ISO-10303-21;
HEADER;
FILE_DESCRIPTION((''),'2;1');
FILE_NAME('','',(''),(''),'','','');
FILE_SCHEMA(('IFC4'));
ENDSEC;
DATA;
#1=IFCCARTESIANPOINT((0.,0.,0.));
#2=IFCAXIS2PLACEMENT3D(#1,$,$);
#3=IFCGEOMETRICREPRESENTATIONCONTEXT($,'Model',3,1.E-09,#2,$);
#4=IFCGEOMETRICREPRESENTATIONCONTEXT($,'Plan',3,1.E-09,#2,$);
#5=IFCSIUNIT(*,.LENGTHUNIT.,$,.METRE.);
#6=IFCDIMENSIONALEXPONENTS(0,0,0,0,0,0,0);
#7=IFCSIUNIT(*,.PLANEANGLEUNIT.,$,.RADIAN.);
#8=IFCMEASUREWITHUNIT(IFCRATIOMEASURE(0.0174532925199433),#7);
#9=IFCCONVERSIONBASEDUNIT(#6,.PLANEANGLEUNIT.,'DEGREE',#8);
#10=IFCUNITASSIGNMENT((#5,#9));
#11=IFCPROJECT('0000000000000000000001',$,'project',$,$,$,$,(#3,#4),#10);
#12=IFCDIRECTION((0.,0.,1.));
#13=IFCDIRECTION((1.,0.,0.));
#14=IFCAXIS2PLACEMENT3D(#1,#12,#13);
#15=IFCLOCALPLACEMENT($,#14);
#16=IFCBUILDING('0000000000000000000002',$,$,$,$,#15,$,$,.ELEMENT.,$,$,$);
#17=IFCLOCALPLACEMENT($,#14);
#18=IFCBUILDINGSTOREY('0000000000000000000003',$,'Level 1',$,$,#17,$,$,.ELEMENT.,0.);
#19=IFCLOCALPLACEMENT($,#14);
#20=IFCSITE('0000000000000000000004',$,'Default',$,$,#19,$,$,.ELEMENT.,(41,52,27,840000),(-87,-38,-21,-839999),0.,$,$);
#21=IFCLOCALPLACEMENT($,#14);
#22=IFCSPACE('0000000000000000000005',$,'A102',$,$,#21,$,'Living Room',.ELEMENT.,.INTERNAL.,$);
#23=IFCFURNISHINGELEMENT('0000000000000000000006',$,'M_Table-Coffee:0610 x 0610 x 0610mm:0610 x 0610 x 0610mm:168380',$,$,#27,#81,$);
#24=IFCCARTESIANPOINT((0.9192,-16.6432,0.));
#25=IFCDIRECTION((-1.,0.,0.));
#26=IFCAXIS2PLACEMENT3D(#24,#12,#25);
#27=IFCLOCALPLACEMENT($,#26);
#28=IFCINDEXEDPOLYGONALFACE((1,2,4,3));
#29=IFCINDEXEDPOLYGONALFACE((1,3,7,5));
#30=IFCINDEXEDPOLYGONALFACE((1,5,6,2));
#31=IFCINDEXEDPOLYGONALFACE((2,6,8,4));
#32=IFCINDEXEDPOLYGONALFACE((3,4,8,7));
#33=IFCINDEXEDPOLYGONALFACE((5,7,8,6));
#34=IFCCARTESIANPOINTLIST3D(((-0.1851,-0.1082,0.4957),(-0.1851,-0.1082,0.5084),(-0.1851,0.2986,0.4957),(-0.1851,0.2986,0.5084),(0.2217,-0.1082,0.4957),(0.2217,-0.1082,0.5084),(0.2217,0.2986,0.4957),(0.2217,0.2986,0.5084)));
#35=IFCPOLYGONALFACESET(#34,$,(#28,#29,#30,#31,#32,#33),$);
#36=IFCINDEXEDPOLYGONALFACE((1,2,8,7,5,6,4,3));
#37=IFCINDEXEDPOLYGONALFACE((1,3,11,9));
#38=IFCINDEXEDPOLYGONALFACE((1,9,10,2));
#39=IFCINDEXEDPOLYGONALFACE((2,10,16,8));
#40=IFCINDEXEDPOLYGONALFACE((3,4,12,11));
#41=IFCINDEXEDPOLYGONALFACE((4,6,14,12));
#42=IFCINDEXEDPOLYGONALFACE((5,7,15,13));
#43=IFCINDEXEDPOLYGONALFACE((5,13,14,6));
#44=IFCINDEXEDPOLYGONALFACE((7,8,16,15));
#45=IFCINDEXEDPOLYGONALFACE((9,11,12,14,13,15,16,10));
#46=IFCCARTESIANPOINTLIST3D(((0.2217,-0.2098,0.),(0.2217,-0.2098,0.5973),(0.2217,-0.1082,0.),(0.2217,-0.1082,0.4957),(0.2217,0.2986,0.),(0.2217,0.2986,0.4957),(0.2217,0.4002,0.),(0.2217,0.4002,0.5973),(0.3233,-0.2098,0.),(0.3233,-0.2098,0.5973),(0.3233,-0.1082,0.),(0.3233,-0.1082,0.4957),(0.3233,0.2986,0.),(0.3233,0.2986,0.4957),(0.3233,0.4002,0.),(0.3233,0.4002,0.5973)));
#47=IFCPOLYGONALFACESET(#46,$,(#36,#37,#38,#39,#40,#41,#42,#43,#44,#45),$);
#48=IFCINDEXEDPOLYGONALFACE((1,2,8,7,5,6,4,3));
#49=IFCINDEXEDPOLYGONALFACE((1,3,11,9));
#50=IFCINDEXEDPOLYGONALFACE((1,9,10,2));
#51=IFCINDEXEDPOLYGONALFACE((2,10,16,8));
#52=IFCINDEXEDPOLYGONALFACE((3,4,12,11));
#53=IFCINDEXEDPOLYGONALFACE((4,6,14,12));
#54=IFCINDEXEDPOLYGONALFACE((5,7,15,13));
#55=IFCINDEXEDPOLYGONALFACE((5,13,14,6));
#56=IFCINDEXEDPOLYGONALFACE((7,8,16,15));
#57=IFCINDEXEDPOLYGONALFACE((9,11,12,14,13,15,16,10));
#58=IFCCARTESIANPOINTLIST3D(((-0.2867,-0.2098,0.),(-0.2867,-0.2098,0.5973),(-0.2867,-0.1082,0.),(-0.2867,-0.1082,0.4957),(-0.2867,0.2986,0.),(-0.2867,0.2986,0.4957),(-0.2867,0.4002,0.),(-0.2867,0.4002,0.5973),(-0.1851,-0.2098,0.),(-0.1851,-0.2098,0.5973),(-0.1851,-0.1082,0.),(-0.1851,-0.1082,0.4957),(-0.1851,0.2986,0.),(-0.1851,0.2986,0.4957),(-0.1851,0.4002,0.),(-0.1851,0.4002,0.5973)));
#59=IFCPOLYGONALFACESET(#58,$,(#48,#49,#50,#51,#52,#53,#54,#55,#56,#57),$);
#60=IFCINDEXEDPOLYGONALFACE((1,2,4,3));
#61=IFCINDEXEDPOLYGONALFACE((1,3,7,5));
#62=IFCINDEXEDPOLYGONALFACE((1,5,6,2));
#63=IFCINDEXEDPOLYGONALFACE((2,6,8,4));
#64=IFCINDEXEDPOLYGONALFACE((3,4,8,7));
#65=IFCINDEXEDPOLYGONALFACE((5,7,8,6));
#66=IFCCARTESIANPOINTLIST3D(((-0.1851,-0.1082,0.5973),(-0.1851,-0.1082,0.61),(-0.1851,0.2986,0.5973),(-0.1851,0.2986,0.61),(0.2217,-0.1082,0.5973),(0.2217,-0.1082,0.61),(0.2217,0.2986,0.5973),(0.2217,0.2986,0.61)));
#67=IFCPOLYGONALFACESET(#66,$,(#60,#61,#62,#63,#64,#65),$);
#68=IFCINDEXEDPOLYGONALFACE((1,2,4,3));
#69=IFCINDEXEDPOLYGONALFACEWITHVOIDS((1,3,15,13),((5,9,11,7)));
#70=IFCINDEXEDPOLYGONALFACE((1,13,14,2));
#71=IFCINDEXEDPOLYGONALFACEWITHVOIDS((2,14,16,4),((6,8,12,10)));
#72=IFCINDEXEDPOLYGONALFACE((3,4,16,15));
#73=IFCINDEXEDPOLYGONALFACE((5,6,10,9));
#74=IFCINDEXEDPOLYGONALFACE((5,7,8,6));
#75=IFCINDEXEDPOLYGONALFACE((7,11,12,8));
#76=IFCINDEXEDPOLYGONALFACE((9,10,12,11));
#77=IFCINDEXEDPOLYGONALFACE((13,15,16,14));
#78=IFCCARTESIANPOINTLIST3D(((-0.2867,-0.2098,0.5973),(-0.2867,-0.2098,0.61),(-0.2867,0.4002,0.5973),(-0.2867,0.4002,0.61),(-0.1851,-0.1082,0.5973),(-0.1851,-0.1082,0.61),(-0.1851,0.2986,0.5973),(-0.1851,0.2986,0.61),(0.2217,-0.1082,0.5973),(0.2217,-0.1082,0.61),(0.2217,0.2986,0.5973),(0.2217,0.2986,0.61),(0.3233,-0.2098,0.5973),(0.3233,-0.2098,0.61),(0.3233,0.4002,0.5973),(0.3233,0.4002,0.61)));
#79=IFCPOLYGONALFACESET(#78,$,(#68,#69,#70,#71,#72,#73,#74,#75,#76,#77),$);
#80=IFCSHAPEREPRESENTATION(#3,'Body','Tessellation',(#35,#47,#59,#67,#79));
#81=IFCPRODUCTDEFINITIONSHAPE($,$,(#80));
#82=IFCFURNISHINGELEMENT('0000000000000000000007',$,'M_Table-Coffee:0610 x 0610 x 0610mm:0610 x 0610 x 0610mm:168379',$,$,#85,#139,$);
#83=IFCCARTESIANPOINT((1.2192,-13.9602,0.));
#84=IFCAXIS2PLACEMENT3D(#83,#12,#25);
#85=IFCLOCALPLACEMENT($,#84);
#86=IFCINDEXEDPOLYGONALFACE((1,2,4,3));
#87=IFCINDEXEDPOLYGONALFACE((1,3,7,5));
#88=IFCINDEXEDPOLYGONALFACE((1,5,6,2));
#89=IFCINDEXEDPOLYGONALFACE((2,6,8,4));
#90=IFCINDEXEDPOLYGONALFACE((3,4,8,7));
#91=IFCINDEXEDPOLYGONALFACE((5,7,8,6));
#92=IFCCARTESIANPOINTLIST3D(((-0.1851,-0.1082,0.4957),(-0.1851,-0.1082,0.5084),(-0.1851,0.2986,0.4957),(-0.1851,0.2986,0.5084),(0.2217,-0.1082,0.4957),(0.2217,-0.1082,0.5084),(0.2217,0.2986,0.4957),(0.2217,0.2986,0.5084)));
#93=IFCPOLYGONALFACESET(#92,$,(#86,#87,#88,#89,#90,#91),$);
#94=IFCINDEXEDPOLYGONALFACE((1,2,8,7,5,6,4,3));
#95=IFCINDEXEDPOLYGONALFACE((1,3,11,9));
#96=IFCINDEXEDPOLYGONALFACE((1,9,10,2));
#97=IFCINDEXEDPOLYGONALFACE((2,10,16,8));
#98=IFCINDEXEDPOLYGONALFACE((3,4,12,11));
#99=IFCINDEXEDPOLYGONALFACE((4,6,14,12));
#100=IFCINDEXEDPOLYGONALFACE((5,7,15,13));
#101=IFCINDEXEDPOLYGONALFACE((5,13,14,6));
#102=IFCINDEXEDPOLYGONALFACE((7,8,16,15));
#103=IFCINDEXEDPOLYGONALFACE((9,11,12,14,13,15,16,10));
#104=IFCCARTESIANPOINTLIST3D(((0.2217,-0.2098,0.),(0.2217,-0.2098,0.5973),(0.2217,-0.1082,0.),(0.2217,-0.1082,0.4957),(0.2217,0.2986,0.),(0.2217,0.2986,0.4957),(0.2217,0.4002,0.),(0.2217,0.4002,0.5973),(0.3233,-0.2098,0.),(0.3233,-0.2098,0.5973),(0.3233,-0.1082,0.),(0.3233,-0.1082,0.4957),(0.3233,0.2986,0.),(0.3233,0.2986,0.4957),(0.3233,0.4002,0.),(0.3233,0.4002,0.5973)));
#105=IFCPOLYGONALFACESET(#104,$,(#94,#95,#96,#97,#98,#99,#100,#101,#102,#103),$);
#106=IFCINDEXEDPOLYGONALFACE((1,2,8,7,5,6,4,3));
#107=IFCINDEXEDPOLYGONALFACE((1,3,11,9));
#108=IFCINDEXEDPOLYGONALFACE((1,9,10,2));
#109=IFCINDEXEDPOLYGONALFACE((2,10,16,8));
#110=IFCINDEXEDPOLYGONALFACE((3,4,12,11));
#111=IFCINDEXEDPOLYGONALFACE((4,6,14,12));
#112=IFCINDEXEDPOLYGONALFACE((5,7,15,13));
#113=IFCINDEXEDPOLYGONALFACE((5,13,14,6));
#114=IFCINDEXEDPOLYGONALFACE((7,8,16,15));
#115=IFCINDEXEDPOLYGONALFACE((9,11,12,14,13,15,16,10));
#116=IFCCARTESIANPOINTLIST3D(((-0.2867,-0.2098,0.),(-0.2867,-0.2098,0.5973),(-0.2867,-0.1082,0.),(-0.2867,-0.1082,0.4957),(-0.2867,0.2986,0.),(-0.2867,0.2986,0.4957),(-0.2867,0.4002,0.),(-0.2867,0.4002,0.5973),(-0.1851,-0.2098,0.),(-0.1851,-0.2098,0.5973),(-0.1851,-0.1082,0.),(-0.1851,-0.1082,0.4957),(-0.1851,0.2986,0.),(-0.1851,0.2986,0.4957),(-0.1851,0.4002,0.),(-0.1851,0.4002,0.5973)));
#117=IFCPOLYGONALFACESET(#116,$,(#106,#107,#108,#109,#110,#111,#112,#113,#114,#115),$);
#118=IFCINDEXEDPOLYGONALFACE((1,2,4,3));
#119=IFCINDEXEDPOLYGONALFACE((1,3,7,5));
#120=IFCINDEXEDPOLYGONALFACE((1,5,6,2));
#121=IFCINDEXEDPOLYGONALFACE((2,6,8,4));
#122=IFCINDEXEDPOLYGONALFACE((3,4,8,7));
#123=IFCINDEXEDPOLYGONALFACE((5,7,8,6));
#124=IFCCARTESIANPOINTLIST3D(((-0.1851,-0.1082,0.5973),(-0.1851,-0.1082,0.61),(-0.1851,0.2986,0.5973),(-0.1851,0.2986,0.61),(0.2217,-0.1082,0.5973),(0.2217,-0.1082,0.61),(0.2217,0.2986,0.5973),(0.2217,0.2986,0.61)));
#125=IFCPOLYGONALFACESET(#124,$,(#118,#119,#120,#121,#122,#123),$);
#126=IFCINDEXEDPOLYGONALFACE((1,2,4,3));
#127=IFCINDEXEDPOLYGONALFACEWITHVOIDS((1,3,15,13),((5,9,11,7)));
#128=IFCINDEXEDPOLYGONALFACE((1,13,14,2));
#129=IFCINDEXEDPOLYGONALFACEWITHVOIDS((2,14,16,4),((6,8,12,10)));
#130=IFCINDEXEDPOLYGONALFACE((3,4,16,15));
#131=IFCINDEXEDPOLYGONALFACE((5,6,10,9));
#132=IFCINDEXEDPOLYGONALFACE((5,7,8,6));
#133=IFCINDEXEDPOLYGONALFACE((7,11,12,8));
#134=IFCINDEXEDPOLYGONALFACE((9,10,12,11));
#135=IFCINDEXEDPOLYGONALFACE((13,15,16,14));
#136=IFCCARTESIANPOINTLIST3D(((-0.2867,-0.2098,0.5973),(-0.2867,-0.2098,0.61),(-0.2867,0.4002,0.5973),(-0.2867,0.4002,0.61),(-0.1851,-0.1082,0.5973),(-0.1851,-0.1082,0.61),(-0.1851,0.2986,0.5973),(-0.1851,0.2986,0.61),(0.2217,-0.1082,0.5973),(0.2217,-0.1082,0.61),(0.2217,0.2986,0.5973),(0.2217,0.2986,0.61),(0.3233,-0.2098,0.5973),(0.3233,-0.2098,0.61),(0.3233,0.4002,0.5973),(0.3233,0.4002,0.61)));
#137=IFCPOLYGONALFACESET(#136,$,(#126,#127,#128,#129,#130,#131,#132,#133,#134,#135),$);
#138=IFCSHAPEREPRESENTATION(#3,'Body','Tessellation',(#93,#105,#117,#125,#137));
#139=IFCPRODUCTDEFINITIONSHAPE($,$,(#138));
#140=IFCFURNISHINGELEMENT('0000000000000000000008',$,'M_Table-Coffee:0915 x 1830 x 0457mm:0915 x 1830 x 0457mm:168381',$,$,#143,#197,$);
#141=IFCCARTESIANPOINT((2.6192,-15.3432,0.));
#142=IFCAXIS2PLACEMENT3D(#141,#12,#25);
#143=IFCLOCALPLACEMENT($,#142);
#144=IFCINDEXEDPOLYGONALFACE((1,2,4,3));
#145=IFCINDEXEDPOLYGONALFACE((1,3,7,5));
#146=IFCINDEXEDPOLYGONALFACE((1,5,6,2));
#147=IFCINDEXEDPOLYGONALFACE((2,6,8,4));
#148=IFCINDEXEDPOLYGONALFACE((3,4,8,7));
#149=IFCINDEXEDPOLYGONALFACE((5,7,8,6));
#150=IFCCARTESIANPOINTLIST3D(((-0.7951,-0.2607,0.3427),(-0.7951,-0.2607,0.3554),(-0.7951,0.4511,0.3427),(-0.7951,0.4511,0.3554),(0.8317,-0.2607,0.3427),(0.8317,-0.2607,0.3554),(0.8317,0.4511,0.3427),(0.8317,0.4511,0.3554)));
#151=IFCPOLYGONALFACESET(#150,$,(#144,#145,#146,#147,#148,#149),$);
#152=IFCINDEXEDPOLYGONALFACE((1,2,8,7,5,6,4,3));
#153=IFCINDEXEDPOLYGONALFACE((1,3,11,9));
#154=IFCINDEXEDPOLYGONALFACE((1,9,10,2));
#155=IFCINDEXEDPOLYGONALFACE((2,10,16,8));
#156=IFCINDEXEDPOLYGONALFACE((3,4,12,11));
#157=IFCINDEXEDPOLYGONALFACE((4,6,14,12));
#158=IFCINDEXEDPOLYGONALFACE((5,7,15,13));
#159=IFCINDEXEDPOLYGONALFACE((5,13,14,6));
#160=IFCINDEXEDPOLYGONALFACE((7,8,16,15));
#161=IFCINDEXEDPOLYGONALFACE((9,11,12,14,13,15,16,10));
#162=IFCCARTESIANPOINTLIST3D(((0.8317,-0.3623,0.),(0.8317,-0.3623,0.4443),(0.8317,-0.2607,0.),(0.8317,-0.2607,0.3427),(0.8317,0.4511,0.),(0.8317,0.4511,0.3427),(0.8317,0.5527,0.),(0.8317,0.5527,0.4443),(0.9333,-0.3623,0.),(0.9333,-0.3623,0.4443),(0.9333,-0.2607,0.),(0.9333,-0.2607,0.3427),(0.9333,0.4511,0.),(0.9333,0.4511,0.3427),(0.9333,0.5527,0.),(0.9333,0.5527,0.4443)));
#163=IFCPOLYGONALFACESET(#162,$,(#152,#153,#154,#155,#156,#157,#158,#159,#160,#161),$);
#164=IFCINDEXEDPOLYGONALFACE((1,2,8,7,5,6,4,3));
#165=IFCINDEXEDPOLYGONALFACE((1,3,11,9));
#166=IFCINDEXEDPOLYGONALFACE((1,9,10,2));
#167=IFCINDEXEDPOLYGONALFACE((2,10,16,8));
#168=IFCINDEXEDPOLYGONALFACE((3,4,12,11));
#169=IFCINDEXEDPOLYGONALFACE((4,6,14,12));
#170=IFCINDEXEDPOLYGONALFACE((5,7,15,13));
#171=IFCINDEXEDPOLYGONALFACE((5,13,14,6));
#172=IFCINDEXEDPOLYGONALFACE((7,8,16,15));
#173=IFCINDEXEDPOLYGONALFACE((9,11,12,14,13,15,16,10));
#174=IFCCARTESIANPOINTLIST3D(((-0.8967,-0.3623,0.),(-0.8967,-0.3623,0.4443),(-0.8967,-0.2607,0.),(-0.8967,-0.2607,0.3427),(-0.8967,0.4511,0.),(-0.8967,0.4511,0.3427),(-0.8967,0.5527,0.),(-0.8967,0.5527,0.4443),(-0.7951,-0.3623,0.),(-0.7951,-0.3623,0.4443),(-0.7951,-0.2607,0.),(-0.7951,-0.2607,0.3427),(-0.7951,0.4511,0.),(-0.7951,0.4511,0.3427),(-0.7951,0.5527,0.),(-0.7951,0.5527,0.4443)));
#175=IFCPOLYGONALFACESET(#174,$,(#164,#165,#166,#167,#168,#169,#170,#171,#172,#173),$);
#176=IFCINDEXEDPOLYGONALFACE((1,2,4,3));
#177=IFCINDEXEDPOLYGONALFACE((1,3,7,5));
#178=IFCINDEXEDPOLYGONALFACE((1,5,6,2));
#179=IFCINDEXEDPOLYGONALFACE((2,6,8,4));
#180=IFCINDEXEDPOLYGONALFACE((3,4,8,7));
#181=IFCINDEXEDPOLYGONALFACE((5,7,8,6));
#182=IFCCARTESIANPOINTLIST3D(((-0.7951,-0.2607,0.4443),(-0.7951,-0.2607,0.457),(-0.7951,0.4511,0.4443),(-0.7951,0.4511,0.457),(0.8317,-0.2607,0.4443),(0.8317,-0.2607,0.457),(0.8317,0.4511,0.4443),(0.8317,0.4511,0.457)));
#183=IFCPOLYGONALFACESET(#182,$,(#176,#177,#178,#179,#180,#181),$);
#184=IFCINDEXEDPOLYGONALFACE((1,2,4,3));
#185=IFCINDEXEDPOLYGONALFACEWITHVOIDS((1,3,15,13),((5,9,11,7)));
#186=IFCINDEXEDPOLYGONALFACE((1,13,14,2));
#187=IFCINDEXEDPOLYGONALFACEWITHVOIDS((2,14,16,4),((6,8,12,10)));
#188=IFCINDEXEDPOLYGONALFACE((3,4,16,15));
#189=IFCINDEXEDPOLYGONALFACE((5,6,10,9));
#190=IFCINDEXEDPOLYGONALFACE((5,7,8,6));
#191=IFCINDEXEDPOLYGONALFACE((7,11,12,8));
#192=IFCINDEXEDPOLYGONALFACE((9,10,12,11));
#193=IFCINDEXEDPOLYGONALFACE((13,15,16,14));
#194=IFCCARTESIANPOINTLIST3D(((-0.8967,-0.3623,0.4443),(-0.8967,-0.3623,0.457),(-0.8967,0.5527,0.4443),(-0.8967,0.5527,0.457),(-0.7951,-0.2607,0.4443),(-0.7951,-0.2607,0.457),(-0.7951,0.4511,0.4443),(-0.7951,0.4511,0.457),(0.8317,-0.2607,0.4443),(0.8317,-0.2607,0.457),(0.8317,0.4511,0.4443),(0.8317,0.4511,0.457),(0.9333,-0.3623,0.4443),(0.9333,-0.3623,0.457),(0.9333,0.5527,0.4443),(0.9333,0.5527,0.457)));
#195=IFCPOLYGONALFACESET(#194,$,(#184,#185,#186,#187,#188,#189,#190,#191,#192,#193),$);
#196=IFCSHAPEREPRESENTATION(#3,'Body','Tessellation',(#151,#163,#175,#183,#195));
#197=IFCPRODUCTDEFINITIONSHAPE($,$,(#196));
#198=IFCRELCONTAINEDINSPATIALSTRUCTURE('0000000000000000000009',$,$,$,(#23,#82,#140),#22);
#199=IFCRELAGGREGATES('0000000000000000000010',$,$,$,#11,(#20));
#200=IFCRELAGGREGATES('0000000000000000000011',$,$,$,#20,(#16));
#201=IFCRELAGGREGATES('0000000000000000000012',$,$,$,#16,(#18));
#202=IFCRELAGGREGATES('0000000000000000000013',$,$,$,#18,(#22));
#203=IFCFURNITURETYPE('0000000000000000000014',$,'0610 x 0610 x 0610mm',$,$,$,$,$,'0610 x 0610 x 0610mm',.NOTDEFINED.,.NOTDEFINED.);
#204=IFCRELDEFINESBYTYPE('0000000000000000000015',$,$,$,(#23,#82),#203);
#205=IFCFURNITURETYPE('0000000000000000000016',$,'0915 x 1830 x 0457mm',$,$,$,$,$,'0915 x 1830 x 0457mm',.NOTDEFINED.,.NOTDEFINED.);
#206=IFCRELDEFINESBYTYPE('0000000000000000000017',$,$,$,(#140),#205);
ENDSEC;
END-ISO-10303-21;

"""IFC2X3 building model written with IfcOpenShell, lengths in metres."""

from ifc_helpers import new_model, entity, si_unit, converted_unit, frame, origin, origin_with_axes, origin_2d_with_axis, place, context, project, spatial, polyline, rectangle, outline, extrude, source, transform, mapped, type_object, type_shapes, element, save


model = new_model("IFC2X3")

# Units and contexts
model_context = context("Model", 3, precision=1e-09, world=origin())
plan_context = context("Plan", 3, precision=1e-09, world=origin())
ifc_project = project(units=[si_unit("LENGTHUNIT", "METRE"), converted_unit("PLANEANGLEUNIT", "DEGREE", entity("IfcRatioMeasure", 0.0174532925199433), si_unit("PLANEANGLEUNIT", "RADIAN"), dimensions=[0, 0, 0, 0, 0, 0, 0])], contexts=[model_context, plan_context])

# Site, building, storey, space
site_placement = place(None, origin_with_axes())
site = spatial("IfcSite", under=ifc_project, at=site_placement, Name="Default", CompositionType="ELEMENT", RefLatitude=(41, 52, 27, 840000), RefLongitude=(-87, -38, -21, -839999), RefElevation=0.0)
building_placement = place(None, origin_with_axes())
building = spatial("IfcBuilding", under=site, at=building_placement, CompositionType="ELEMENT")
storey_placement = place(None, origin_with_axes())
storey = spatial("IfcBuildingStorey", under=building, at=storey_placement, Name="Level 1", CompositionType="ELEMENT", Elevation=0.0)
space_placement = place(None, origin_with_axes())
space = spatial("IfcSpace", under=storey, at=space_placement, Name="A102", LongName="Living Room", CompositionType="ELEMENT", InteriorOrExteriorSpace="INTERNAL")

# Furnishing elements
furniture_type_1 = type_object("IfcFurnitureType", Name="0610 x 0610 x 0610mm", ElementType="0610 x 0610 x 0610mm", AssemblyPlace="NOTDEFINED")
shared_shape_1 = source(origin(), model_context, "Body", "SweptSolid", [
    extrude(rectangle(XDim=0.4068, YDim=0.4068, at=origin_2d_with_axis()), frame((0.0183, 0.0952, 0.4957), z_axis=(0.0, 0.0, 1.0), x_axis=(-1.0, 0.0, 0.0)), (0.0, 0.0, 1.0), 0.0127),
    extrude(outline(polyline([(-0.2732, -0.305), (0.324, -0.305), (0.324, 0.305), (-0.2732, 0.305), (-0.2732, 0.2034), (0.2225, 0.2034), (0.2225, -0.2034), (-0.2732, -0.2034), (-0.2732, -0.305)])), frame((0.2217, 0.0952, 0.2732), z_axis=(1.0, 0.0, 0.0), x_axis=(0.0, 0.0, 1.0)), (0.0, 0.0, 1.0), 0.1016),
    extrude(outline(polyline([(-0.305, -0.3241), (0.305, -0.3241), (0.305, 0.2733), (0.2034, 0.2733), (0.2034, -0.2224), (-0.2034, -0.2224), (-0.2034, 0.2733), (-0.305, 0.2733), (-0.305, -0.3241)])), frame((-0.2867, 0.0952, 0.2733), z_axis=(1.0, 0.0, 0.0), x_axis=(0.0, -1.0, 0.0)), (0.0, 0.0, 1.0), 0.1016),
    extrude(rectangle(XDim=0.4068, YDim=0.4068, at=origin_2d_with_axis()), frame((0.0183, 0.0952, 0.5973), z_axis=(0.0, 0.0, 1.0), x_axis=(-1.0, 0.0, 0.0)), (0.0, 0.0, 1.0), 0.0127),
    extrude(outline(polyline([(-0.305, -0.305), (0.305, -0.305), (0.305, 0.305), (-0.305, 0.305), (-0.305, -0.305)]), holes=[polyline([(-0.2034, -0.2034), (-0.2034, 0.2034), (0.2034, 0.2034), (0.2034, -0.2034), (-0.2034, -0.2034)])]), frame((0.0183, 0.0952, 0.5973), z_axis=(0.0, 0.0, 1.0), x_axis=(-1.0, 0.0, 0.0)), (0.0, 0.0, 1.0), 0.0127),
])
type_shapes(furniture_type_1, [shared_shape_1])
for number, where, z_axis, x_axis, name in (
    (1, (0.9192, -16.6432, 0.0), (0.0, 0.0, 1.0), (-1.0, 0.0, 0.0), "M_Table-Coffee:0610 x 0610 x 0610mm:0610 x 0610 x 0610mm:168380"),
    (2, (1.2192, -13.9602, 0.0), (0.0, 0.0, 1.0), (-1.0, 0.0, 0.0), "M_Table-Coffee:0610 x 0610 x 0610mm:0610 x 0610 x 0610mm:168379"),
):
    element("IfcFurnishingElement", number, at=place(None, frame(where, z_axis=z_axis, x_axis=x_axis)), inside=space, type_object=furniture_type_1, Name=name, context=model_context, shape_type="MappedRepresentation", body=[
        mapped(shared_shape_1, transform((0.0, 0.0, 0.0), scale=1.0)),
    ])
furniture_type_2 = type_object("IfcFurnitureType", Name="0915 x 1830 x 0457mm", ElementType="0915 x 1830 x 0457mm", AssemblyPlace="NOTDEFINED")
shared_shape_2 = source(origin(), model_context, "Body", "SweptSolid", [
    extrude(rectangle(XDim=1.6268, YDim=0.7118, at=origin_2d_with_axis()), frame((0.0183, 0.0952, 0.3427), z_axis=(0.0, 0.0, 1.0), x_axis=(-1.0, 0.0, 0.0)), (0.0, 0.0, 1.0), 0.0127),
    extrude(outline(polyline([(-0.1967, -0.4575), (0.2475, -0.4575), (0.2475, 0.4575), (-0.1967, 0.4575), (-0.1967, 0.3559), (0.146, 0.3559), (0.146, -0.3559), (-0.1967, -0.3559), (-0.1967, -0.4575)])), frame((0.8317, 0.0952, 0.1967), z_axis=(1.0, 0.0, 0.0), x_axis=(0.0, 0.0, 1.0)), (0.0, 0.0, 1.0), 0.1016),
    extrude(outline(polyline([(-0.4575, -0.2476), (0.4575, -0.2476), (0.4575, 0.1968), (0.3559, 0.1968), (0.3559, -0.1459), (-0.3559, -0.1459), (-0.3559, 0.1968), (-0.4575, 0.1968), (-0.4575, -0.2476)])), frame((-0.8967, 0.0952, 0.1968), z_axis=(1.0, 0.0, 0.0), x_axis=(0.0, -1.0, 0.0)), (0.0, 0.0, 1.0), 0.1016),
    extrude(rectangle(XDim=1.6268, YDim=0.7118, at=origin_2d_with_axis()), frame((0.0183, 0.0952, 0.4443), z_axis=(0.0, 0.0, 1.0), x_axis=(-1.0, 0.0, 0.0)), (0.0, 0.0, 1.0), 0.0127),
    extrude(outline(polyline([(-0.915, -0.4575), (0.915, -0.4575), (0.915, 0.4575), (-0.915, 0.4575), (-0.915, -0.4575)]), holes=[polyline([(-0.8134, -0.3559), (-0.8134, 0.3559), (0.8134, 0.3559), (0.8134, -0.3559), (-0.8134, -0.3559)])]), frame((0.0183, 0.0952, 0.4443), z_axis=(0.0, 0.0, 1.0), x_axis=(-1.0, 0.0, 0.0)), (0.0, 0.0, 1.0), 0.0127),
])
type_shapes(furniture_type_2, [shared_shape_2])
furnishing_placement = place(None, frame((2.6192, -15.3432, 0.0), z_axis=(0.0, 0.0, 1.0), x_axis=(-1.0, 0.0, 0.0)))
element("IfcFurnishingElement", 3, at=furnishing_placement, inside=space, type_object=furniture_type_2, Name="M_Table-Coffee:0915 x 1830 x 0457mm:0915 x 1830 x 0457mm:168381", context=model_context, shape_type="MappedRepresentation", body=[
    mapped(shared_shape_2, transform((0.0, 0.0, 0.0), scale=1.0)),
])

save(model, "model.ifc")
